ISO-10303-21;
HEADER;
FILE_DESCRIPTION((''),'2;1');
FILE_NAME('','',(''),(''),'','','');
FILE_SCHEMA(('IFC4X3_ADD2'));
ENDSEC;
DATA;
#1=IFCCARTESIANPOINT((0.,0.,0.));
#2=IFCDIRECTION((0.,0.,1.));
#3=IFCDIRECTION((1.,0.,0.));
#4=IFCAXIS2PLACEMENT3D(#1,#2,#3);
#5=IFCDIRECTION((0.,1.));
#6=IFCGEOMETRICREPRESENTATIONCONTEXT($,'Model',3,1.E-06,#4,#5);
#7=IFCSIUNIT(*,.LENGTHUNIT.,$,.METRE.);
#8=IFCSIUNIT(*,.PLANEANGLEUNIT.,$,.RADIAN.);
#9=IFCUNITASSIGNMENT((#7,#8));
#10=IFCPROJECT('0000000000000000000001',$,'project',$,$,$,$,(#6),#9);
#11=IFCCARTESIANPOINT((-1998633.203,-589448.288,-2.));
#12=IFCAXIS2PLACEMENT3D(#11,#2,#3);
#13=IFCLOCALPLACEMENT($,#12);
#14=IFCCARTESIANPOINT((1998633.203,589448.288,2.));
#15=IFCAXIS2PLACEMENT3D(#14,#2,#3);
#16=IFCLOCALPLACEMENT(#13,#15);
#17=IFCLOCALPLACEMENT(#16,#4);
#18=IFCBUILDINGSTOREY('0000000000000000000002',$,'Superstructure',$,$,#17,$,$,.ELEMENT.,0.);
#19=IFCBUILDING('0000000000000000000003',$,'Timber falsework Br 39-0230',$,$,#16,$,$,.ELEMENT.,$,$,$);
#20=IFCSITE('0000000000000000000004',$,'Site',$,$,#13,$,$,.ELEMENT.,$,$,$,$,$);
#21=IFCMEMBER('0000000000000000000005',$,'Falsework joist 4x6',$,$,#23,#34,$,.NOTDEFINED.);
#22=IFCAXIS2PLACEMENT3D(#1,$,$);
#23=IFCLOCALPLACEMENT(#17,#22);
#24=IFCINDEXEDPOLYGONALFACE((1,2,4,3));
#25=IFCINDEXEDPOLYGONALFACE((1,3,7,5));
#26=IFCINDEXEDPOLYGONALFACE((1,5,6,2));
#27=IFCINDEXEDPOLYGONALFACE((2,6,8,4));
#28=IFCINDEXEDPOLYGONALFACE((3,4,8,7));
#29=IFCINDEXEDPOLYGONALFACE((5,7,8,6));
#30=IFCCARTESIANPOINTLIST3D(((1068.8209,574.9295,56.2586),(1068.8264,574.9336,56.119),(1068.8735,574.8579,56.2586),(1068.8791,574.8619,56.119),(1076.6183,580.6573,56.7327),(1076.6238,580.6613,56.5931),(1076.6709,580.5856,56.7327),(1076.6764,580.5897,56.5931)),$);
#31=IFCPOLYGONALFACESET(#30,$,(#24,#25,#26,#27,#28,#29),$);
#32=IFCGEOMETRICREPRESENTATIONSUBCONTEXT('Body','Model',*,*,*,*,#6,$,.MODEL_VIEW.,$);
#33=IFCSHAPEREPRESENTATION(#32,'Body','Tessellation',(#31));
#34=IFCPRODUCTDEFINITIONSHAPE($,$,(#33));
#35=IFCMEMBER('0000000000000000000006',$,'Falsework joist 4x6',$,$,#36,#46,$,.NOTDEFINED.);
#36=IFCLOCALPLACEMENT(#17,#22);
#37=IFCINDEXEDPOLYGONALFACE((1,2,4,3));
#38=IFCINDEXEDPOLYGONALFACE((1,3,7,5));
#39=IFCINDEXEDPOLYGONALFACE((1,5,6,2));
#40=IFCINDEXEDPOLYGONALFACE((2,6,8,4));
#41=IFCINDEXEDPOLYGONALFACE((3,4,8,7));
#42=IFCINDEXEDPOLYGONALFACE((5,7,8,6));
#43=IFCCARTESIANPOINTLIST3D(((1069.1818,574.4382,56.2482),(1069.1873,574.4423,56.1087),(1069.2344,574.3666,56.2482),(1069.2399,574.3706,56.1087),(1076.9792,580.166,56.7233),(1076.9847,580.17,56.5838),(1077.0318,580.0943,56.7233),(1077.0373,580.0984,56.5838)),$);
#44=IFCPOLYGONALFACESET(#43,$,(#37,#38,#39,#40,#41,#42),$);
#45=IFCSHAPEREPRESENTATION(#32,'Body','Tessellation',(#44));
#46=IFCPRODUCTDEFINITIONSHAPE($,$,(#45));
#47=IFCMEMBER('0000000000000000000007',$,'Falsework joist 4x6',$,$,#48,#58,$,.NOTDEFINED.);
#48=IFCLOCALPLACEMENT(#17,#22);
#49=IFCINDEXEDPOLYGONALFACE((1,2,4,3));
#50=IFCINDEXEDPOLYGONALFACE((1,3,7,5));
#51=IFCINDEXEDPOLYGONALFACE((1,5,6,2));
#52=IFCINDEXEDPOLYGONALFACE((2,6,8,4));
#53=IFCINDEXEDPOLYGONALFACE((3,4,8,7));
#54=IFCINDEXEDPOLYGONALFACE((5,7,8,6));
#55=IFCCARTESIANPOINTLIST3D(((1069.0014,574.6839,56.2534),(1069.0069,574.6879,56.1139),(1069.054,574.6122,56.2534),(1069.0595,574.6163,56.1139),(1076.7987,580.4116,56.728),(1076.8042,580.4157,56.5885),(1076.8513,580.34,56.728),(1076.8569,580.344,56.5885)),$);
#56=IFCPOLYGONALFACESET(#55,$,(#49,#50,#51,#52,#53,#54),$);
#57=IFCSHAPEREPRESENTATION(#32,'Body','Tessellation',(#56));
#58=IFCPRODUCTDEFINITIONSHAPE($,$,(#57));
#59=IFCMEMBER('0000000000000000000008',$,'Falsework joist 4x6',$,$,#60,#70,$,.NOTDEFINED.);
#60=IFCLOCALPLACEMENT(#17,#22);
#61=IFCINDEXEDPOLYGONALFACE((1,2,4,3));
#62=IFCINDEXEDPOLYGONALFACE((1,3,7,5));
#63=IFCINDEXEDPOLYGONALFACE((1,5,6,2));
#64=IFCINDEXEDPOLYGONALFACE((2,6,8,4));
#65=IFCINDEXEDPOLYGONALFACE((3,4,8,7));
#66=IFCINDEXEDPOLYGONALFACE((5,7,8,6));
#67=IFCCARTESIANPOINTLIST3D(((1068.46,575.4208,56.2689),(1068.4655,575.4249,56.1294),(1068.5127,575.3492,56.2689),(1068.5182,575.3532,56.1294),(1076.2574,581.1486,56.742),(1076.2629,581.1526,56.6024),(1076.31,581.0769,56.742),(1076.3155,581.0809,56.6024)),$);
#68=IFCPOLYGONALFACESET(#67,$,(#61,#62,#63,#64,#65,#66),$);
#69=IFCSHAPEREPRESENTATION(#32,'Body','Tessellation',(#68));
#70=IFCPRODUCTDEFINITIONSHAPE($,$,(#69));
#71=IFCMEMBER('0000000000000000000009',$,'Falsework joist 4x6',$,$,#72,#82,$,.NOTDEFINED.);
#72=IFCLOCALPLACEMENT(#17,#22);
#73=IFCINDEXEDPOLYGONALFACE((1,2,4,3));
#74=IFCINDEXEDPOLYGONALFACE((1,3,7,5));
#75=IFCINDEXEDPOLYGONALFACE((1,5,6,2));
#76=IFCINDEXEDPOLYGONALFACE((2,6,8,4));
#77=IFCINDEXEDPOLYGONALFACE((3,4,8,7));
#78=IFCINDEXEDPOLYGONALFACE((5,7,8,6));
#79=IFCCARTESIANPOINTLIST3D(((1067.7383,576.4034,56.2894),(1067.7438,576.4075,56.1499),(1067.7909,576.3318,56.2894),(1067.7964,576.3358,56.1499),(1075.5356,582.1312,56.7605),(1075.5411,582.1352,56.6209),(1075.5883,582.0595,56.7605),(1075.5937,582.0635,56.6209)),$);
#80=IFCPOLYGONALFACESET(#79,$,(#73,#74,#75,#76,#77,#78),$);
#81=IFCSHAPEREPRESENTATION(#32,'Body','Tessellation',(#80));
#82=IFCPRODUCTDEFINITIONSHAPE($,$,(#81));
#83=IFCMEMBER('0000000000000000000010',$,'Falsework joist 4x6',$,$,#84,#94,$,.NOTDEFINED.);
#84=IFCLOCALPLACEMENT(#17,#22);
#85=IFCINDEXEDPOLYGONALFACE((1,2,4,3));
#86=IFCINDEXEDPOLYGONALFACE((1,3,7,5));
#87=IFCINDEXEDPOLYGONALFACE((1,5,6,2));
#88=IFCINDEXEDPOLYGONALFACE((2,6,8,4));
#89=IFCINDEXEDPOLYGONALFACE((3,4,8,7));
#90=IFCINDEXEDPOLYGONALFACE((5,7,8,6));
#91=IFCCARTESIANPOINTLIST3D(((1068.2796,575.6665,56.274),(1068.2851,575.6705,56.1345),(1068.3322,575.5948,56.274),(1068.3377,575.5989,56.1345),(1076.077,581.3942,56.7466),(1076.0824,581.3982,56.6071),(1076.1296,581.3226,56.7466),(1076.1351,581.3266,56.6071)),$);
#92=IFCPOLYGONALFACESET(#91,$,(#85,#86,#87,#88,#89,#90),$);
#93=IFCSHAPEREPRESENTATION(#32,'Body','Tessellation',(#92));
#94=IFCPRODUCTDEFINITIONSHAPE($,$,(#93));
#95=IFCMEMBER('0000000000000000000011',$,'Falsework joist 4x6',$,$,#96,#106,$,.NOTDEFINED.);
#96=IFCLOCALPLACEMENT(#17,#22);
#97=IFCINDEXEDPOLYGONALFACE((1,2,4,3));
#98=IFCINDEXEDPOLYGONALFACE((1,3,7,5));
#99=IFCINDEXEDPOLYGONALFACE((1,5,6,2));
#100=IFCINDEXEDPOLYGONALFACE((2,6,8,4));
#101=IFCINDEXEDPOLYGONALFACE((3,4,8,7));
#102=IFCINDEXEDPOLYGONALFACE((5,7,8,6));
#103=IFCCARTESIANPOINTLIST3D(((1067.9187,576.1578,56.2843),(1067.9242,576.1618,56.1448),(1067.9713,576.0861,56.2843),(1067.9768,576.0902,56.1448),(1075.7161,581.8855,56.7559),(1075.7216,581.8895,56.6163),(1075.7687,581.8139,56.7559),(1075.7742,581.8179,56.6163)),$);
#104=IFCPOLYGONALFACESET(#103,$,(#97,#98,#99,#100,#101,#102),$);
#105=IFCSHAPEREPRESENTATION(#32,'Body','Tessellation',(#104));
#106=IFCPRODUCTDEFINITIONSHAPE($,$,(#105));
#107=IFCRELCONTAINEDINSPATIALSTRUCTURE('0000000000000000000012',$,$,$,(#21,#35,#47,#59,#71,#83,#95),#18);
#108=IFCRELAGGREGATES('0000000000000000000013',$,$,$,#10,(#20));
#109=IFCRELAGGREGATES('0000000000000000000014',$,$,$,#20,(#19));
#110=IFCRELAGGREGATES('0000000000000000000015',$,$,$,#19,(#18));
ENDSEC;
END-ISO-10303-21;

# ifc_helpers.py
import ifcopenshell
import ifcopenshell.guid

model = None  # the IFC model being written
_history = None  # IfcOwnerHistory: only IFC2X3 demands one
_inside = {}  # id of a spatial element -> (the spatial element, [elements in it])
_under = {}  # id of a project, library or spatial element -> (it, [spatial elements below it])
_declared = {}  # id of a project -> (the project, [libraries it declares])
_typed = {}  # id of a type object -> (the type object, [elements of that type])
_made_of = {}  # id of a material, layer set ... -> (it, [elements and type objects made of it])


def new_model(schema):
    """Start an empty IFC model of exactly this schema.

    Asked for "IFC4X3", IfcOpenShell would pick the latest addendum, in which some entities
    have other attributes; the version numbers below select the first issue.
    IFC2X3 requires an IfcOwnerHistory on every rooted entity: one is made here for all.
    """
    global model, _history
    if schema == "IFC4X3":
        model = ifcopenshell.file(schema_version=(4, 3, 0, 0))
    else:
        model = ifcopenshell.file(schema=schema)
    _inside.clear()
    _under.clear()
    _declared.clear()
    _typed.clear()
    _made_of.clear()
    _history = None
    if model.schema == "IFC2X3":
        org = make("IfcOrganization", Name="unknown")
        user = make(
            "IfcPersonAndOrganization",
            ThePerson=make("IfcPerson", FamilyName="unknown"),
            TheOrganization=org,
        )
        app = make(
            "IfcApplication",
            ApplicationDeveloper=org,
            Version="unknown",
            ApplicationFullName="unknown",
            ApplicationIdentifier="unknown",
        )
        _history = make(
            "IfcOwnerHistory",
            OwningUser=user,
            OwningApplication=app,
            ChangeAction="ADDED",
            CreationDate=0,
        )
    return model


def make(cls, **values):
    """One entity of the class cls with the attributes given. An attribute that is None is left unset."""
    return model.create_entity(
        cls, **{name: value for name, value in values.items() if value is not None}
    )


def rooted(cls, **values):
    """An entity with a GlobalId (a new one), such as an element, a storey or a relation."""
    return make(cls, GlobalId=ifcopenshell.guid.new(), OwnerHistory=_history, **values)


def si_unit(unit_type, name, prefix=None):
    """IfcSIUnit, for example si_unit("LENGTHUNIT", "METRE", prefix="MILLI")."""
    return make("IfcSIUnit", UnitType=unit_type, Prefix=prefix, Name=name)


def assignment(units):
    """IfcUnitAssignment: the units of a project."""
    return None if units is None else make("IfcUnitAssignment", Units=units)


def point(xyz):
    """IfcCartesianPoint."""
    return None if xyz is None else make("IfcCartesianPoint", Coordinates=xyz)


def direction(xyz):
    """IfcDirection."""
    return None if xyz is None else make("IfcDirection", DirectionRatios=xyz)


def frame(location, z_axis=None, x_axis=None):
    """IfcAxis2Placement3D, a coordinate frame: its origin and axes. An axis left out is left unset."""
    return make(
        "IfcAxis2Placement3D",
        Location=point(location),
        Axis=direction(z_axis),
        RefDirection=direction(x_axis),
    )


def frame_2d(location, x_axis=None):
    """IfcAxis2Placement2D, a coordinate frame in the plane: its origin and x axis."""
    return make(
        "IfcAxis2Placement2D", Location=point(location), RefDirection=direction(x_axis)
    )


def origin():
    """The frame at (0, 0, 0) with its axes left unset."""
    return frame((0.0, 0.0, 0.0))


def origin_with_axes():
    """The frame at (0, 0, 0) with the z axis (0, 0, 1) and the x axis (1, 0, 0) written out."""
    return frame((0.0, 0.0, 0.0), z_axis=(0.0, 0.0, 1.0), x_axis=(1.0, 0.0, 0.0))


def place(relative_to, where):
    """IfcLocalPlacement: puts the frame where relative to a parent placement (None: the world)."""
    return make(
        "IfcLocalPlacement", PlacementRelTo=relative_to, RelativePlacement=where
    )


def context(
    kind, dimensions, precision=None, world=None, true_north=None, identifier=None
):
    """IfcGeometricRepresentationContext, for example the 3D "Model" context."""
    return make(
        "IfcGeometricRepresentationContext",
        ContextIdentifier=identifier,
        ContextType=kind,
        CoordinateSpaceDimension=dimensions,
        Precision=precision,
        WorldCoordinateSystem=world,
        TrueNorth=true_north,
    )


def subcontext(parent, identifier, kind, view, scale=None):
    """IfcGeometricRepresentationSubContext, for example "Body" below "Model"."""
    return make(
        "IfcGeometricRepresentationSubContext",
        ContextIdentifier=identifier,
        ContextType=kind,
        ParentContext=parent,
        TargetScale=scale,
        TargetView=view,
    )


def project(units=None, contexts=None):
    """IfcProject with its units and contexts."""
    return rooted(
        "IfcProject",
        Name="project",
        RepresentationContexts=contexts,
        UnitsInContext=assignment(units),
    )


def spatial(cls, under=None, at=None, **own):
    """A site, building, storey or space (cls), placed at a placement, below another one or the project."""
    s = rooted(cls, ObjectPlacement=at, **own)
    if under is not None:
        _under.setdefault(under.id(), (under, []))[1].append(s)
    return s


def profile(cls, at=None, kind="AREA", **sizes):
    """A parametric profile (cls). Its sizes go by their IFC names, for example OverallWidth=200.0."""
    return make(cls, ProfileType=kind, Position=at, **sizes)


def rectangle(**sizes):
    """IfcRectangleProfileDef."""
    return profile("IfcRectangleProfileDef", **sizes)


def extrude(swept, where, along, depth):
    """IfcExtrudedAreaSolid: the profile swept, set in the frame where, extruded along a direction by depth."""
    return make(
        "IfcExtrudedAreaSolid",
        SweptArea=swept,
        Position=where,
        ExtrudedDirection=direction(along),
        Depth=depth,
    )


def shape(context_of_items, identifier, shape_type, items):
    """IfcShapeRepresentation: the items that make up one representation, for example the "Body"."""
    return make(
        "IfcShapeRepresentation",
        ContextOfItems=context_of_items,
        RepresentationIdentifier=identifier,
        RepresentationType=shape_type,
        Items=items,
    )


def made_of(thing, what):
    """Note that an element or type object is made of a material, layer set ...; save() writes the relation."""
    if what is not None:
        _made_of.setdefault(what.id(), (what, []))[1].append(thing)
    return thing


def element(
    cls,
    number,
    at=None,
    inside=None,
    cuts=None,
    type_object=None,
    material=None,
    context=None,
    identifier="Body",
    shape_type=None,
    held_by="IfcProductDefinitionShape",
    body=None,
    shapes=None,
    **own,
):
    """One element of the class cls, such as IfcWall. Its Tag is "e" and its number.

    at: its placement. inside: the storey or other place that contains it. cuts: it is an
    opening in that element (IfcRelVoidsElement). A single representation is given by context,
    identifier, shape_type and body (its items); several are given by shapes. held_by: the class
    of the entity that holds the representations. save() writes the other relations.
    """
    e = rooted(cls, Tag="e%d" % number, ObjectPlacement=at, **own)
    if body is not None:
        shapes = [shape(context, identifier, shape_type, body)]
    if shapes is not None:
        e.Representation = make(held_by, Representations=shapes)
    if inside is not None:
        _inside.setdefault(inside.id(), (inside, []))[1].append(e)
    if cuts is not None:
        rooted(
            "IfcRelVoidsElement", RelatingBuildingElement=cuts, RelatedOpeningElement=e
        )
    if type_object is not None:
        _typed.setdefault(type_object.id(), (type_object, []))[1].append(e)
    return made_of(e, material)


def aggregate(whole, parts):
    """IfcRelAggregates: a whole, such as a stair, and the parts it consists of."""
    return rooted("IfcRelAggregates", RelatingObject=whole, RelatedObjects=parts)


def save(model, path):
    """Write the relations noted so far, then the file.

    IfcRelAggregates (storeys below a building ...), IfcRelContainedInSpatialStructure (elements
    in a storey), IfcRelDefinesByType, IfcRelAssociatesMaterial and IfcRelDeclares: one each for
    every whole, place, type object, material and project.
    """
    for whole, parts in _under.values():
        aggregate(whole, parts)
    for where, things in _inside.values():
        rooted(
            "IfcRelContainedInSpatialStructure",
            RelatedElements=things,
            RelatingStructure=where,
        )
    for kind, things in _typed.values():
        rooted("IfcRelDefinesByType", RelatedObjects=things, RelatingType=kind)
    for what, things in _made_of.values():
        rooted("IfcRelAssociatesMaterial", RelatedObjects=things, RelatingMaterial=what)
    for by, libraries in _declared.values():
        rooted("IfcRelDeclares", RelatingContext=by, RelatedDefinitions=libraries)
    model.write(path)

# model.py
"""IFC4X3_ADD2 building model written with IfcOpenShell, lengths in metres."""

from ifc_helpers import new_model, si_unit, direction, frame, frame_2d, origin, origin_with_axes, place, context, subcontext, project, spatial, rectangle, extrude, element, save


model = new_model("IFC4X3_ADD2")

# Units and contexts
model_context = context("Model", 3, precision=1e-06, world=origin_with_axes(), true_north=direction((0.0, 1.0)))
body_context = subcontext(model_context, "Body", "Model", "MODEL_VIEW")
ifc_project = project(units=[si_unit("LENGTHUNIT", "METRE"), si_unit("PLANEANGLEUNIT", "RADIAN")], contexts=[model_context])

# Site, building, storey
site_placement = place(None, frame((-1998633.203, -589448.288, -2.0), z_axis=(0.0, 0.0, 1.0), x_axis=(1.0, 0.0, 0.0)))
site = spatial("IfcSite", under=ifc_project, at=site_placement, Name="Site", CompositionType="ELEMENT")
building_placement = place(site_placement, frame((1998633.203, 589448.288, 2.0), z_axis=(0.0, 0.0, 1.0), x_axis=(1.0, 0.0, 0.0)))
building = spatial("IfcBuilding", under=site, at=building_placement, Name="Timber falsework Br 39-0230", CompositionType="ELEMENT")
storey_placement = place(building_placement, origin_with_axes())
storey = spatial("IfcBuildingStorey", under=building, at=storey_placement, Name="Superstructure", CompositionType="ELEMENT", Elevation=0.0)

# Members
member_1_placement = place(storey_placement, frame((1068.8527, 574.8978, 56.119), z_axis=(0.804962, 0.591304, 0.048942), x_axis=(-0.592013, 0.805928, 0.0)))
element("IfcMember", 1, at=member_1_placement, inside=storey, Name="Falsework joist 4x6", PredefinedType="NOTDEFINED", context=body_context, shape_type="SweptSolid", body=[
    extrude(rectangle(XDim=0.0889, YDim=0.1397, at=frame_2d((0.0, 0.0698))), origin(), (0.0, 0.0, 1.0), 9.6866),
])
member_2_placement = place(storey_placement, frame((1069.2136, 574.4065, 56.1087), z_axis=(0.804958, 0.591301, 0.049046), x_axis=(-0.592013, 0.805928, 0.0)))
element("IfcMember", 2, at=member_2_placement, inside=storey, Name="Falsework joist 4x6", PredefinedType="NOTDEFINED", context=body_context, shape_type="SweptSolid", body=[
    extrude(rectangle(XDim=0.0889, YDim=0.1397, at=frame_2d((0.0, 0.0698))), origin(), (0.0, 0.0, 1.0), 9.6867),
])
member_3_placement = place(storey_placement, frame((1069.0332, 574.6521, 56.1139), z_axis=(0.80496, 0.591302, 0.048994), x_axis=(-0.592013, 0.805928, 0.0)))
element("IfcMember", 3, at=member_3_placement, inside=storey, Name="Falsework joist 4x6", PredefinedType="NOTDEFINED", context=body_context, shape_type="SweptSolid", body=[
    extrude(rectangle(XDim=0.0889, YDim=0.1397, at=frame_2d((0.0, 0.0698))), origin(), (0.0, 0.0, 1.0), 9.6866),
])
member_4_placement = place(storey_placement, frame((1068.4919, 575.389, 56.1294), z_axis=(0.804967, 0.591307, 0.048838), x_axis=(-0.592013, 0.805928, 0.0)))
element("IfcMember", 4, at=member_4_placement, inside=storey, Name="Falsework joist 4x6", PredefinedType="NOTDEFINED", context=body_context, shape_type="SweptSolid", body=[
    extrude(rectangle(XDim=0.0889, YDim=0.1397, at=frame_2d((0.0, 0.0698))), origin(), (0.0, 0.0, 1.0), 9.6866),
])
member_5_placement = place(storey_placement, frame((1067.7701, 576.3716, 56.1499), z_axis=(0.804975, 0.591313, 0.048631), x_axis=(-0.592013, 0.805928, 0.0)))
element("IfcMember", 5, at=member_5_placement, inside=storey, Name="Falsework joist 4x6", PredefinedType="NOTDEFINED", context=body_context, shape_type="SweptSolid", body=[
    extrude(rectangle(XDim=0.0889, YDim=0.1397, at=frame_2d((0.0, 0.0698))), origin(), (0.0, 0.0, 1.0), 9.6865),
])
member_6_placement = place(storey_placement, frame((1068.3114, 575.6347, 56.1345), z_axis=(0.804969, 0.591308, 0.048786), x_axis=(-0.592013, 0.805928, 0.0)))
element("IfcMember", 6, at=member_6_placement, inside=storey, Name="Falsework joist 4x6", PredefinedType="NOTDEFINED", context=body_context, shape_type="SweptSolid", body=[
    extrude(rectangle(XDim=0.0889, YDim=0.1397, at=frame_2d((0.0, 0.0698))), origin(), (0.0, 0.0, 1.0), 9.6865),
])
member_7_placement = place(storey_placement, frame((1067.9505, 576.126, 56.1448), z_axis=(0.804973, 0.591311, 0.048683), x_axis=(-0.592013, 0.805928, 0.0)))
element("IfcMember", 7, at=member_7_placement, inside=storey, Name="Falsework joist 4x6", PredefinedType="NOTDEFINED", context=body_context, shape_type="SweptSolid", body=[
    extrude(rectangle(XDim=0.0889, YDim=0.1397, at=frame_2d((0.0, 0.0698))), origin(), (0.0, 0.0, 1.0), 9.6865),
])

save(model, "model.ifc")
